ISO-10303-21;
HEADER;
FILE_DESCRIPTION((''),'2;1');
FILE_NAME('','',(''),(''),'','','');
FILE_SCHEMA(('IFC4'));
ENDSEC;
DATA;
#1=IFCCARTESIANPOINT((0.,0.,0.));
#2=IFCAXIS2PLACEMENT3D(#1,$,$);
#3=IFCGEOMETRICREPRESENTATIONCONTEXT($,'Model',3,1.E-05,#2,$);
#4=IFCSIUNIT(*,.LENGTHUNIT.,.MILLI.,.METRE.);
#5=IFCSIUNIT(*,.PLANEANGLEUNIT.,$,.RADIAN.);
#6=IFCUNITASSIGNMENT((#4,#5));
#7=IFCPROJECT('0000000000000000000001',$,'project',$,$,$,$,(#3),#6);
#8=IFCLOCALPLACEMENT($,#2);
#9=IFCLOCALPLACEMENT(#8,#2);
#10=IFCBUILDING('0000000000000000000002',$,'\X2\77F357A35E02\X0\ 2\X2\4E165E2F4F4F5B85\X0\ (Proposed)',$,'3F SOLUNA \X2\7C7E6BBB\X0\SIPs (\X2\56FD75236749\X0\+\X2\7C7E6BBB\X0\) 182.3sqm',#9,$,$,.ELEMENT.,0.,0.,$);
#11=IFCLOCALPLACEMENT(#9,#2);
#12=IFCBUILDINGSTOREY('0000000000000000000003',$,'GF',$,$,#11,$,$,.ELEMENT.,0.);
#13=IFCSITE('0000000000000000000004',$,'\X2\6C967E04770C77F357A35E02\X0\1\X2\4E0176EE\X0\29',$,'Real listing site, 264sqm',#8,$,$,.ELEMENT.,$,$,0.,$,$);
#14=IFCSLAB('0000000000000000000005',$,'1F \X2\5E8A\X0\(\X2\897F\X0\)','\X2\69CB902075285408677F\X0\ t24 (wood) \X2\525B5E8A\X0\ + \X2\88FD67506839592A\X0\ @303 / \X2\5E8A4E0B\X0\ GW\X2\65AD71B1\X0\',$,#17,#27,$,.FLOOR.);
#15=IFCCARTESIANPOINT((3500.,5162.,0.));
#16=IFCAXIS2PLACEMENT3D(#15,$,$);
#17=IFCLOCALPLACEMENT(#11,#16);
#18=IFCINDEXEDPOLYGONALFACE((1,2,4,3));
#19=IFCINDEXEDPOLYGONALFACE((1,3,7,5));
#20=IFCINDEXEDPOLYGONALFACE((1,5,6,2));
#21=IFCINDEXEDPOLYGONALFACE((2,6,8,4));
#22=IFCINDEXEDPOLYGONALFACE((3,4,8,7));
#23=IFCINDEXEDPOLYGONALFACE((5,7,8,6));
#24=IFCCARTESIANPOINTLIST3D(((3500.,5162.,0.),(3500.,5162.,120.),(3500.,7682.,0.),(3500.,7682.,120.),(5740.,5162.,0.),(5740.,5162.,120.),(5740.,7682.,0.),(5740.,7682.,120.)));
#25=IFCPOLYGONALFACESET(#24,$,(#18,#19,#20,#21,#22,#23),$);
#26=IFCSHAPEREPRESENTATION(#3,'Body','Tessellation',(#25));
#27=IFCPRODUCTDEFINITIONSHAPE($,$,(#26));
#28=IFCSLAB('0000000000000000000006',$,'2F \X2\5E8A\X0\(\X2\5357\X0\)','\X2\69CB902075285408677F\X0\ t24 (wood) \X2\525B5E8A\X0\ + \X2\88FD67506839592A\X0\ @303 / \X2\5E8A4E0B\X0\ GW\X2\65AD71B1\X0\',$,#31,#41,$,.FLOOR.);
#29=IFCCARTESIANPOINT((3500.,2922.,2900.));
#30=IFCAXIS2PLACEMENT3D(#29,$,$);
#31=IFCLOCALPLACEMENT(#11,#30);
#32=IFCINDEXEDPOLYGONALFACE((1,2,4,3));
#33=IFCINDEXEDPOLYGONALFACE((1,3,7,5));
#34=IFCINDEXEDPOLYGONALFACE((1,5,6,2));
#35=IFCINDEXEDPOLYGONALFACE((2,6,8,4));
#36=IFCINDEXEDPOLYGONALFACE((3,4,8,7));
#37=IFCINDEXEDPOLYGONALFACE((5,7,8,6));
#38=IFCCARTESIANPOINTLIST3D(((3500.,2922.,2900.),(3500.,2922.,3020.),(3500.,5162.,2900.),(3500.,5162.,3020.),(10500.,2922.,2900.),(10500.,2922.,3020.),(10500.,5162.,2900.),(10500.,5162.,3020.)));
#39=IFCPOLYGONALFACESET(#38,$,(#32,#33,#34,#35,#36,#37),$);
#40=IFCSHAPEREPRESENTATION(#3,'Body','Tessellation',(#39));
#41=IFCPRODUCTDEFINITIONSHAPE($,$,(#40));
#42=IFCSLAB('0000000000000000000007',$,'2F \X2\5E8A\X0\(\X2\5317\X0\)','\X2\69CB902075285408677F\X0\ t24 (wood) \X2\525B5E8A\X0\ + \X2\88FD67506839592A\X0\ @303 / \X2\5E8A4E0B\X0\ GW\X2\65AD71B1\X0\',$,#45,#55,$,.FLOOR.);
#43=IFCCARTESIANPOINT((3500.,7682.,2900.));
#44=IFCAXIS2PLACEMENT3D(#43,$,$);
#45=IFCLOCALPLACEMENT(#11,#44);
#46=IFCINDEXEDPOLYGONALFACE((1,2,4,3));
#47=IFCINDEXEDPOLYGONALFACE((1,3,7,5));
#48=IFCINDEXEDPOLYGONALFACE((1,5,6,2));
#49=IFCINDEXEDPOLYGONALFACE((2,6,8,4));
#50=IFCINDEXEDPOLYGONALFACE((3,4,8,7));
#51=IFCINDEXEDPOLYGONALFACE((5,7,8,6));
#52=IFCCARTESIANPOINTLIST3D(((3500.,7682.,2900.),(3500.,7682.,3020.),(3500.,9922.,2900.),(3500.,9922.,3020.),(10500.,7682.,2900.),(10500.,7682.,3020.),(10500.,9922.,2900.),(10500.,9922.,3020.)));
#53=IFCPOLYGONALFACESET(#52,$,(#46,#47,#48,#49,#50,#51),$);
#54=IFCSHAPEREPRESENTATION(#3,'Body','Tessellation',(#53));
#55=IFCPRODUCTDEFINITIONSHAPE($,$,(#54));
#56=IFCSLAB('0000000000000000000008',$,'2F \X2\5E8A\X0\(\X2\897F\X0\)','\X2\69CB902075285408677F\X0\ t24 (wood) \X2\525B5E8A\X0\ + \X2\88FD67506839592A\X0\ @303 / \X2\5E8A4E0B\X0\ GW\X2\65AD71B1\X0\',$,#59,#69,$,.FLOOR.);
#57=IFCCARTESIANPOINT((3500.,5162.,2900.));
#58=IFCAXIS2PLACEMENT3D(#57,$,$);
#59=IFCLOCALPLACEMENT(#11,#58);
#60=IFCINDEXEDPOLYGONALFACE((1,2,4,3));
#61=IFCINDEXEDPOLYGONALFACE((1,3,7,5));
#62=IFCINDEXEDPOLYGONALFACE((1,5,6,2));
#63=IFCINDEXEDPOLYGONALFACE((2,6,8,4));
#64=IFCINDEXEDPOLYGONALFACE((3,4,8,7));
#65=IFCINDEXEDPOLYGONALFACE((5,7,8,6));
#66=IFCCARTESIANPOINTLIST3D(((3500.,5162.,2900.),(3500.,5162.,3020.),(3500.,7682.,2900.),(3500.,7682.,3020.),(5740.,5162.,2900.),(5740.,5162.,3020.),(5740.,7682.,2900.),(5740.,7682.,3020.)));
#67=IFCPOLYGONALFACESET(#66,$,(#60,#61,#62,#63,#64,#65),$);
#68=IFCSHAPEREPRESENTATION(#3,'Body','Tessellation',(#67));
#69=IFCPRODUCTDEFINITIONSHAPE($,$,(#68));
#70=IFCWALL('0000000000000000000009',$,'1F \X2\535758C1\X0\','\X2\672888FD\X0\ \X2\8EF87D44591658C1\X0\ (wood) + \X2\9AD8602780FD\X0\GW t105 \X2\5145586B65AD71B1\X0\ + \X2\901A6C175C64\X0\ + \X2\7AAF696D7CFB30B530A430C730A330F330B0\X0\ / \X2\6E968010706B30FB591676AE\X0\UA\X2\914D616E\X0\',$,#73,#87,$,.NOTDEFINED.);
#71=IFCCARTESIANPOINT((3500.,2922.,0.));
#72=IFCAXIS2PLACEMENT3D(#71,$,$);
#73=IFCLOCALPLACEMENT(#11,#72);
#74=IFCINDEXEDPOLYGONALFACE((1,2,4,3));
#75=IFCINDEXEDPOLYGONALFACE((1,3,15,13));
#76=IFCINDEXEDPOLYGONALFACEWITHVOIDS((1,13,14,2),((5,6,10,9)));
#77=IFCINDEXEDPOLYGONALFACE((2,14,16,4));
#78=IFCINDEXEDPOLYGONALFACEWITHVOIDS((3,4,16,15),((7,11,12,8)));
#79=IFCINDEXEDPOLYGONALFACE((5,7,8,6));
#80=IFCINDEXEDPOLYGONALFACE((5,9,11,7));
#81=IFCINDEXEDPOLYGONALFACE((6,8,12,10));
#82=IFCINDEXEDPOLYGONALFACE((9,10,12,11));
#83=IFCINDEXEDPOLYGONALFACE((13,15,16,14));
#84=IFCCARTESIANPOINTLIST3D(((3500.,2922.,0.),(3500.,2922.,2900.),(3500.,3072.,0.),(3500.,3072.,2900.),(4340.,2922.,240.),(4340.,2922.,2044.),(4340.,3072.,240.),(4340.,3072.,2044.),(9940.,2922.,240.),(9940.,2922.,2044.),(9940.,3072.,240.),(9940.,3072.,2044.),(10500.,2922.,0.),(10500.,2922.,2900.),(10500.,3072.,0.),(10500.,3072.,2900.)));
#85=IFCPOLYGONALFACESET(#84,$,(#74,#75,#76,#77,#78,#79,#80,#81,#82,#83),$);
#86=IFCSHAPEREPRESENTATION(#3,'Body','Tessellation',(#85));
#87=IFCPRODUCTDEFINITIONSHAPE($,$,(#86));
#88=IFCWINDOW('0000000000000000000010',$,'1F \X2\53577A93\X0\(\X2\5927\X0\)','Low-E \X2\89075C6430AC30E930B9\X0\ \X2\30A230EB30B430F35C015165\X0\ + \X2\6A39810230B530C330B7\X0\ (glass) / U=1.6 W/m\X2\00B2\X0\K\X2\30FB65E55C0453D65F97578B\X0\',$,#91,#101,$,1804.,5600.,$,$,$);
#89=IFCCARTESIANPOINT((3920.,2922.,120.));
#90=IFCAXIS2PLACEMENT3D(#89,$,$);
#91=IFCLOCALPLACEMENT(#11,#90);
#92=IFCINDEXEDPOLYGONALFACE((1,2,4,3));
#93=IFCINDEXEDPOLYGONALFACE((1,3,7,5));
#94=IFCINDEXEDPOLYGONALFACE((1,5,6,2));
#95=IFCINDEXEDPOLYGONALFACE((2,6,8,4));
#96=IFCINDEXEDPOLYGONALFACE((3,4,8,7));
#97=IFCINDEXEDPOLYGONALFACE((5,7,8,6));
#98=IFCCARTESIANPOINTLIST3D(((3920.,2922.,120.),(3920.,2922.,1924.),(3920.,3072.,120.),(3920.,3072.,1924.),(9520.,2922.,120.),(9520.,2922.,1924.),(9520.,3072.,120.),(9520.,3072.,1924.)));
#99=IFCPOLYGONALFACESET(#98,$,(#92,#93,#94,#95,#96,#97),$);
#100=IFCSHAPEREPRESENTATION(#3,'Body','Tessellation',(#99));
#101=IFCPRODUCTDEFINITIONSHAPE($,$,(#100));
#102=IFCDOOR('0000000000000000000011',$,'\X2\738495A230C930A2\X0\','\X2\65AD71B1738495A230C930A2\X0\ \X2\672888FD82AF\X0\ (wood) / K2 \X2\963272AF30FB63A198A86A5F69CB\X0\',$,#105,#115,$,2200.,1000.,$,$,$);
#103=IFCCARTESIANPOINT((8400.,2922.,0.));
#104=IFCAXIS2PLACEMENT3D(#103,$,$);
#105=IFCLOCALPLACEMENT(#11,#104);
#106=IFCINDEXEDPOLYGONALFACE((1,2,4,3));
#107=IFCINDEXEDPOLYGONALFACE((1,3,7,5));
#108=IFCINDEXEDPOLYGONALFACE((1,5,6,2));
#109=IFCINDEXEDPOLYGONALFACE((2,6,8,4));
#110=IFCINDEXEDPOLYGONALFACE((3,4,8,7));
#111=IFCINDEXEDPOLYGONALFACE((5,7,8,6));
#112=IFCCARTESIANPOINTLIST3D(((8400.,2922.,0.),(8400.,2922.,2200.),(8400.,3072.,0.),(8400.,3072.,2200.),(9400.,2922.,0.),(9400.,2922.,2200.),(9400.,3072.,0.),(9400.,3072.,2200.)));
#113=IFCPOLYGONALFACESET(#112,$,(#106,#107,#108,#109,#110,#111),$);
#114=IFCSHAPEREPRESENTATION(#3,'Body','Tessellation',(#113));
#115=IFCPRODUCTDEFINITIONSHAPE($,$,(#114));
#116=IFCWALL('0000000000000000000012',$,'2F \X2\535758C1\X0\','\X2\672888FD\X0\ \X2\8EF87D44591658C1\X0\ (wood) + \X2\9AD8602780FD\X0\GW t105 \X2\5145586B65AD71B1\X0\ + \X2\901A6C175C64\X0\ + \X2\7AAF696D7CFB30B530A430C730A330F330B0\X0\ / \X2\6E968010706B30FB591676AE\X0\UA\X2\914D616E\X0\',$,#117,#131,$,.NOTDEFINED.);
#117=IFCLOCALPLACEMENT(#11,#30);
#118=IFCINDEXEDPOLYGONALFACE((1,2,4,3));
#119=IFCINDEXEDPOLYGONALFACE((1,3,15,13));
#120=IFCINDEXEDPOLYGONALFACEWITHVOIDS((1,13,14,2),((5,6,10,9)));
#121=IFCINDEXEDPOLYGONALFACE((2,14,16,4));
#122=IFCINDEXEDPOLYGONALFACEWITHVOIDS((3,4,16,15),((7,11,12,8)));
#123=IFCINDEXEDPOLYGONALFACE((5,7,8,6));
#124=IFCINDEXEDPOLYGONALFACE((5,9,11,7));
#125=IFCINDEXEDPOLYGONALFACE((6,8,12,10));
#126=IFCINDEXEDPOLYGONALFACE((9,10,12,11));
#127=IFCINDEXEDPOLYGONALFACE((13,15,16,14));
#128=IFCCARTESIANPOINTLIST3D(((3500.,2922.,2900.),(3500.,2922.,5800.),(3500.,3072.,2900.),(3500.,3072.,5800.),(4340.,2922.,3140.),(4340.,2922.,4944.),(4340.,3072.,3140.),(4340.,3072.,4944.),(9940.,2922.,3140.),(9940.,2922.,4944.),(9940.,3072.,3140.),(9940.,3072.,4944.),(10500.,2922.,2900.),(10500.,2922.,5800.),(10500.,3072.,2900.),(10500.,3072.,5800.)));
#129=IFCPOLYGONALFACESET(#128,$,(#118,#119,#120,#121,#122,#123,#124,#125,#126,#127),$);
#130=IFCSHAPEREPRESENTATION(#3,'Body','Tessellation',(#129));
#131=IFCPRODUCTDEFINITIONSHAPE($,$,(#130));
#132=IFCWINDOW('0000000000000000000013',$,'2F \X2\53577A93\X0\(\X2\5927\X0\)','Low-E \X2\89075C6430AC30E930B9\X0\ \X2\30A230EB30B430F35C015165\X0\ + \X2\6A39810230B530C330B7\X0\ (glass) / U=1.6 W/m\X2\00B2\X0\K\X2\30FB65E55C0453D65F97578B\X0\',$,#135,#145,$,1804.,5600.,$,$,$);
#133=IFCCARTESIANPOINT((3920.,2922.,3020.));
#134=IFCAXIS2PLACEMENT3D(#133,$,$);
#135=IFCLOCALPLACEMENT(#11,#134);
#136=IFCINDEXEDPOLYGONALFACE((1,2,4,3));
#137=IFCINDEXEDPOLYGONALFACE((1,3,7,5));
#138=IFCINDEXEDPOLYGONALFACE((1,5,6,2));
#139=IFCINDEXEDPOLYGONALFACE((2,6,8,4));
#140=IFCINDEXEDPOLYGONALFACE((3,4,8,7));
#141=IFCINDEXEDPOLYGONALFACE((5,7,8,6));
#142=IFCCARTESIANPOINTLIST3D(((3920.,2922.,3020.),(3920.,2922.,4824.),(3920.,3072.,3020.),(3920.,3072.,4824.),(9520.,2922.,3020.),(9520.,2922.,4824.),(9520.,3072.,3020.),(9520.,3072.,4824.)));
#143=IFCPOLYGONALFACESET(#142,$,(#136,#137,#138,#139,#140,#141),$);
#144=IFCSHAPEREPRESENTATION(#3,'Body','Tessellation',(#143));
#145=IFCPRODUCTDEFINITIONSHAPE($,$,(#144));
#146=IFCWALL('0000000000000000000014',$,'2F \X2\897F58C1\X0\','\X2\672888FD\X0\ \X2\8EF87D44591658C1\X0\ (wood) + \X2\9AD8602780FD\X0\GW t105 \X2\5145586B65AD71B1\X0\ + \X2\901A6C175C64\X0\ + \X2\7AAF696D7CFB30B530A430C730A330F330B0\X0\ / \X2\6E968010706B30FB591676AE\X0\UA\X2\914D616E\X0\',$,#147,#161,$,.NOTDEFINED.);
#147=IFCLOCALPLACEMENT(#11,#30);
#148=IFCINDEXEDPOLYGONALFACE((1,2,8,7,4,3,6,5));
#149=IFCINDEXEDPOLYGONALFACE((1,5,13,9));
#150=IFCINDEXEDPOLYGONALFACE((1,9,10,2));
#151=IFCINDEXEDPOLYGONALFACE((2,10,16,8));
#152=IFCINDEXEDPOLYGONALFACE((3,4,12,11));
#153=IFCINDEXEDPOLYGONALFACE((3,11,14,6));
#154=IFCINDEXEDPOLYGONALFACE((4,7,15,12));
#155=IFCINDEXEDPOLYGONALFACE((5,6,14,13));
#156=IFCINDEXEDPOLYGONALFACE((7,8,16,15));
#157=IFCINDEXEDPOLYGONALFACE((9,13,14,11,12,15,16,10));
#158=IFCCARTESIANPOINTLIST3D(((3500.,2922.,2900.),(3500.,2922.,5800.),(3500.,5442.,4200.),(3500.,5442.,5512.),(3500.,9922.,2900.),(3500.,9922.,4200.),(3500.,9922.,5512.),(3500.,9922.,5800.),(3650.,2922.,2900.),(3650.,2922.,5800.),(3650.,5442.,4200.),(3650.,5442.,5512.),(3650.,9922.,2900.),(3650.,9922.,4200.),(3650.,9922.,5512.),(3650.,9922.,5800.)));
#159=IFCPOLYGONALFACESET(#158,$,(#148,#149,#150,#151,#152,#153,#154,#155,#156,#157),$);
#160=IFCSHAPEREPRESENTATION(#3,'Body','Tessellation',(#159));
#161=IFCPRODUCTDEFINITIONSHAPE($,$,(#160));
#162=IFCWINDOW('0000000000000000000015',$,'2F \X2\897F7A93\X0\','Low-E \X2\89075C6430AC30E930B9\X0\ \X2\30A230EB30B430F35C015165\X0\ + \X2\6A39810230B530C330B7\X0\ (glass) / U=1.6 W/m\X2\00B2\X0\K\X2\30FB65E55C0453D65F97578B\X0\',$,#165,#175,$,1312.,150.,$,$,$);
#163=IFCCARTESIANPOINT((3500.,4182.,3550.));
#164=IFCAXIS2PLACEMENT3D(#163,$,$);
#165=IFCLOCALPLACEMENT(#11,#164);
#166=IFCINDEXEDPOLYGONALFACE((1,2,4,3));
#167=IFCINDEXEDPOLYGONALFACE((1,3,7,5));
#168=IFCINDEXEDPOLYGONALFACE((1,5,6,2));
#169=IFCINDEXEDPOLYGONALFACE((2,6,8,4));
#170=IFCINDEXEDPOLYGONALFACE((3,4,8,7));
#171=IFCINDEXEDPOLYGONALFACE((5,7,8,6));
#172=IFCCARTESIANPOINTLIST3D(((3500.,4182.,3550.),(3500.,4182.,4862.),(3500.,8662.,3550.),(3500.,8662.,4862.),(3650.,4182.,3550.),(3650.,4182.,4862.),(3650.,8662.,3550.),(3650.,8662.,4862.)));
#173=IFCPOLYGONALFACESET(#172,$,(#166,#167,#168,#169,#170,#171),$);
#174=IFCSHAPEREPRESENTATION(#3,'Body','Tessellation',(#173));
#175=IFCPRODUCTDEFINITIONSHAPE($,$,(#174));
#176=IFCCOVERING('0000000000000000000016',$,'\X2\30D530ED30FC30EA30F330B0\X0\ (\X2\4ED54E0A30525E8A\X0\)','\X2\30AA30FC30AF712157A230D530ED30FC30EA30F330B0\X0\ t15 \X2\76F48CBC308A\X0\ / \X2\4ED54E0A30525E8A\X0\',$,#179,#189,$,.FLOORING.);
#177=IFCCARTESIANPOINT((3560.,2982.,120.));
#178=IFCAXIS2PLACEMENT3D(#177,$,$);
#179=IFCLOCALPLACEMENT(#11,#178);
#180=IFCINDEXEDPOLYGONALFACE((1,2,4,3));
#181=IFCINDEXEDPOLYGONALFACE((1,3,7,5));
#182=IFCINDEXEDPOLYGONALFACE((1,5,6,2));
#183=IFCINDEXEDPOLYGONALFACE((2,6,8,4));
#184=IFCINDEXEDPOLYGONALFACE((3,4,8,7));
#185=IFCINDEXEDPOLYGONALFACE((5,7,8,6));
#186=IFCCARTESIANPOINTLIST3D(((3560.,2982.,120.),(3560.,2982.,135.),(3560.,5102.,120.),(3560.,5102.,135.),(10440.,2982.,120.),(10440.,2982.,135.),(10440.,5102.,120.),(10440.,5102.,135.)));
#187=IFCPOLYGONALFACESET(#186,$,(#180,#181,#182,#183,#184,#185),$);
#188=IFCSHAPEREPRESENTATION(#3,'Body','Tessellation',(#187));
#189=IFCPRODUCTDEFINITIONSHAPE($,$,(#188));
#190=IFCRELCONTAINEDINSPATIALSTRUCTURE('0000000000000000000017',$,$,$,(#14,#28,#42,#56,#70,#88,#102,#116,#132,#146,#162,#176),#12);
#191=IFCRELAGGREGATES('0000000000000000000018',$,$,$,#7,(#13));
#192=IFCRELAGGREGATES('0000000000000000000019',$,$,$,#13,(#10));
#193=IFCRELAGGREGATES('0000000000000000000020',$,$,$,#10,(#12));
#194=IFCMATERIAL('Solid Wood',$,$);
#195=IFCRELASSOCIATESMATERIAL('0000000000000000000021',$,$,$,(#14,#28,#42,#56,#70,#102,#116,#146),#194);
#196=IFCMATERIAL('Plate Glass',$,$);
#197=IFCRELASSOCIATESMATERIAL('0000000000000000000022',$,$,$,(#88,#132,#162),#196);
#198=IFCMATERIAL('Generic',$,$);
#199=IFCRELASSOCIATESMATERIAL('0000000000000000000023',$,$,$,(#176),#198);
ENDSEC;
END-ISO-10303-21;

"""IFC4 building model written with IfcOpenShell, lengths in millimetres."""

from ifc_helpers import new_model, si_unit, frame, frame_2d, origin, place, context, project, spatial, rectangle, extrude, material, element, fill, save


model = new_model("IFC4")

# Units and contexts
model_context = context("Model", 3, precision=1e-05, world=origin())
ifc_project = project(units=[si_unit("LENGTHUNIT", "METRE", prefix="MILLI"), si_unit("PLANEANGLEUNIT", "RADIAN")], contexts=[model_context])

# Site, building, storey
site_placement = place(None, origin())
site = spatial("IfcSite", under=ifc_project, at=site_placement, Name="沖縄県石垣市1丁目29", ObjectType="Real listing site, 264sqm", CompositionType="ELEMENT", RefElevation=0.0)
building_placement = place(site_placement, origin())
building = spatial("IfcBuilding", under=site, at=building_placement, Name="石垣市 2世帯住宅 (Proposed)", ObjectType="3F SOLUNA 籾殻SIPs (国産杉+籾殻) 182.3sqm", CompositionType="ELEMENT", ElevationOfRefHeight=0.0, ElevationOfTerrain=0.0)
storey_placement = place(building_placement, origin())
storey = spatial("IfcBuildingStorey", under=building, at=storey_placement, Name="GF", CompositionType="ELEMENT", Elevation=0.0)

# Slabs
ifc_material_1 = material(Name="Solid Wood")
slab_1_placement = place(storey_placement, frame((3500.0, 5162.0, 0.0)))
element("IfcSlab", 1, at=slab_1_placement, inside=storey, material=ifc_material_1, Name="1F 床(西)", Description="構造用合板 t24 (wood) 剛床 + 製材根太 @303 / 床下 GW断熱", PredefinedType="FLOOR", context=model_context, shape_type="SweptSolid", body=[
    extrude(rectangle(XDim=2240.0, YDim=2520.0, at=frame_2d((1120.0, 1260.0))), frame((3500.0, 5162.0, 0.0)), (0.0, 0.0, 1.0), 120.0),
])
slab_2_placement = place(storey_placement, frame((3500.0, 2922.0, 2900.0)))
element("IfcSlab", 2, at=slab_2_placement, inside=storey, material=ifc_material_1, Name="2F 床(南)", Description="構造用合板 t24 (wood) 剛床 + 製材根太 @303 / 床下 GW断熱", PredefinedType="FLOOR", context=model_context, shape_type="SweptSolid", body=[
    extrude(rectangle(XDim=7000.0, YDim=2240.0, at=frame_2d((3500.0, 1120.0))), frame((3500.0, 2922.0, 2900.0)), (0.0, 0.0, 1.0), 120.0),
])
slab_3_placement = place(storey_placement, frame((3500.0, 7682.0, 2900.0)))
element("IfcSlab", 3, at=slab_3_placement, inside=storey, material=ifc_material_1, Name="2F 床(北)", Description="構造用合板 t24 (wood) 剛床 + 製材根太 @303 / 床下 GW断熱", PredefinedType="FLOOR", context=model_context, shape_type="SweptSolid", body=[
    extrude(rectangle(XDim=7000.0, YDim=2240.0, at=frame_2d((3500.0, 1120.0))), frame((3500.0, 7682.0, 2900.0)), (0.0, 0.0, 1.0), 120.0),
])
slab_4_placement = place(storey_placement, frame((3500.0, 5162.0, 2900.0)))
element("IfcSlab", 4, at=slab_4_placement, inside=storey, material=ifc_material_1, Name="2F 床(西)", Description="構造用合板 t24 (wood) 剛床 + 製材根太 @303 / 床下 GW断熱", PredefinedType="FLOOR", context=model_context, shape_type="SweptSolid", body=[
    extrude(rectangle(XDim=2240.0, YDim=2520.0, at=frame_2d((1120.0, 1260.0))), frame((3500.0, 5162.0, 2900.0)), (0.0, 0.0, 1.0), 120.0),
])

# Wall, openings, window, door
wall_1_placement = place(storey_placement, frame((3500.0, 2922.0, 0.0)))
wall_1 = element("IfcWall", 5, at=wall_1_placement, inside=storey, material=ifc_material_1, Name="1F 南壁", Description="木製 軸組外壁 (wood) + 高性能GW t105 充填断熱 + 通気層 + 窯業系サイディング / 準耐火・外皮UA配慮", PredefinedType="NOTDEFINED", context=model_context, shape_type="SweptSolid", body=[
    extrude(rectangle(XDim=7000.0, YDim=150.0, at=frame_2d((3500.0, 75.0))), frame((3500.0, 2922.0, 0.0)), (0.0, 0.0, 1.0), 2900.0),
])
opening_1_placement = place(storey_placement, frame((3920.0, 2922.0, 120.0)))
opening_1 = element("IfcOpeningElement", 6, at=opening_1_placement, cuts=wall_1, PredefinedType="NOTDEFINED", context=model_context, shape_type="SweptSolid", body=[
    extrude(rectangle(XDim=5600.0, YDim=150.0, at=frame_2d((2800.0, 75.0))), frame((3920.0, 2922.0, 120.0)), (0.0, 0.0, 1.0), 1804.0),
])
opening_2_placement = place(storey_placement, frame((8400.0, 2922.0, 0.0)))
opening_2 = element("IfcOpeningElement", 7, at=opening_2_placement, cuts=wall_1, PredefinedType="NOTDEFINED", context=model_context, shape_type="SweptSolid", body=[
    extrude(rectangle(XDim=1000.0, YDim=150.0, at=frame_2d((500.0, 75.0))), frame((8400.0, 2922.0, 0.0)), (0.0, 0.0, 1.0), 2200.0),
])
ifc_material_2 = material(Name="Plate Glass")
window_1_placement = place(storey_placement, frame((3920.0, 2922.0, 120.0)))
window_1 = element("IfcWindow", 8, at=window_1_placement, inside=storey, material=ifc_material_2, Name="1F 南窓(大)", Description="Low-E 複層ガラス アルゴン封入 + 樹脂サッシ (glass) / U=1.6 W/m²K・日射取得型", OverallHeight=1804.0, OverallWidth=5600.0, context=model_context, shape_type="SweptSolid", body=[
    extrude(rectangle(XDim=5600.0, YDim=150.0, at=frame_2d((2800.0, 75.0))), frame((3920.0, 2922.0, 120.0)), (0.0, 0.0, 1.0), 1804.0),
])
fill(opening_1, window_1)
door_placement = place(storey_placement, frame((8400.0, 2922.0, 0.0)))
door = element("IfcDoor", 9, at=door_placement, inside=storey, material=ifc_material_1, Name="玄関ドア", Description="断熱玄関ドア 木製芯 (wood) / K2 防犯・採風機構", OverallHeight=2200.0, OverallWidth=1000.0, context=model_context, shape_type="SweptSolid", body=[
    extrude(rectangle(XDim=1000.0, YDim=150.0, at=frame_2d((500.0, 75.0))), frame((8400.0, 2922.0, 0.0)), (0.0, 0.0, 1.0), 2200.0),
])
fill(opening_2, door)

# Wall, opening, window
wall_2_placement = place(storey_placement, frame((3500.0, 2922.0, 2900.0)))
wall_2 = element("IfcWall", 10, at=wall_2_placement, inside=storey, material=ifc_material_1, Name="2F 南壁", Description="木製 軸組外壁 (wood) + 高性能GW t105 充填断熱 + 通気層 + 窯業系サイディング / 準耐火・外皮UA配慮", PredefinedType="NOTDEFINED", context=model_context, shape_type="SweptSolid", body=[
    extrude(rectangle(XDim=7000.0, YDim=150.0, at=frame_2d((3500.0, 75.0))), frame((3500.0, 2922.0, 2900.0)), (0.0, 0.0, 1.0), 2900.0),
])
opening_3_placement = place(storey_placement, frame((3920.0, 2922.0, 3020.0)))
opening_3 = element("IfcOpeningElement", 11, at=opening_3_placement, cuts=wall_2, PredefinedType="NOTDEFINED", context=model_context, shape_type="SweptSolid", body=[
    extrude(rectangle(XDim=5600.0, YDim=150.0, at=frame_2d((2800.0, 75.0))), frame((3920.0, 2922.0, 3020.0)), (0.0, 0.0, 1.0), 1804.0),
])
window_2_placement = place(storey_placement, frame((3920.0, 2922.0, 3020.0)))
window_2 = element("IfcWindow", 12, at=window_2_placement, inside=storey, material=ifc_material_2, Name="2F 南窓(大)", Description="Low-E 複層ガラス アルゴン封入 + 樹脂サッシ (glass) / U=1.6 W/m²K・日射取得型", OverallHeight=1804.0, OverallWidth=5600.0, context=model_context, shape_type="SweptSolid", body=[
    extrude(rectangle(XDim=5600.0, YDim=150.0, at=frame_2d((2800.0, 75.0))), frame((3920.0, 2922.0, 3020.0)), (0.0, 0.0, 1.0), 1804.0),
])
fill(opening_3, window_2)

# Wall, opening, window
wall_3_placement = place(storey_placement, frame((3500.0, 2922.0, 2900.0)))
wall_3 = element("IfcWall", 13, at=wall_3_placement, inside=storey, material=ifc_material_1, Name="2F 西壁", Description="木製 軸組外壁 (wood) + 高性能GW t105 充填断熱 + 通気層 + 窯業系サイディング / 準耐火・外皮UA配慮", PredefinedType="NOTDEFINED", context=model_context, shape_type="SweptSolid", body=[
    extrude(rectangle(XDim=150.0, YDim=7000.0, at=frame_2d((75.0, 3500.0))), frame((3500.0, 2922.0, 2900.0)), (0.0, 0.0, 1.0), 2900.0),
])
opening_4_placement = place(storey_placement, frame((3500.0, 4182.0, 3550.0)))
opening_4 = element("IfcOpeningElement", 14, at=opening_4_placement, cuts=wall_3, PredefinedType="NOTDEFINED", context=model_context, shape_type="SweptSolid", body=[
    extrude(rectangle(XDim=150.0, YDim=4480.0, at=frame_2d((75.0, 2240.0))), frame((3500.0, 4182.0, 3550.0)), (0.0, 0.0, 1.0), 1312.0),
])
window_3_placement = place(storey_placement, frame((3500.0, 4182.0, 3550.0)))
window_3 = element("IfcWindow", 15, at=window_3_placement, inside=storey, material=ifc_material_2, Name="2F 西窓", Description="Low-E 複層ガラス アルゴン封入 + 樹脂サッシ (glass) / U=1.6 W/m²K・日射取得型", OverallHeight=1312.0, OverallWidth=150.0, context=model_context, shape_type="SweptSolid", body=[
    extrude(rectangle(XDim=150.0, YDim=4480.0, at=frame_2d((75.0, 2240.0))), frame((3500.0, 4182.0, 3550.0)), (0.0, 0.0, 1.0), 1312.0),
])
fill(opening_4, window_3)

# Covering
ifc_material_3 = material(Name="Generic")
covering_1_placement = place(storey_placement, frame((3560.0, 2982.0, 120.0)))
element("IfcCovering", 16, at=covering_1_placement, inside=storey, material=ifc_material_3, Name="フローリング (仕上げ床)", Description="オーク無垢フローリング t15 直貼り / 仕上げ床", PredefinedType="FLOORING", context=model_context, shape_type="SweptSolid", body=[
    extrude(rectangle(XDim=6880.0, YDim=2120.0, at=frame_2d((3440.0, 1060.0))), frame((3560.0, 2982.0, 120.0)), (0.0, 0.0, 1.0), 15.0),
])

save(model, "model.ifc")
